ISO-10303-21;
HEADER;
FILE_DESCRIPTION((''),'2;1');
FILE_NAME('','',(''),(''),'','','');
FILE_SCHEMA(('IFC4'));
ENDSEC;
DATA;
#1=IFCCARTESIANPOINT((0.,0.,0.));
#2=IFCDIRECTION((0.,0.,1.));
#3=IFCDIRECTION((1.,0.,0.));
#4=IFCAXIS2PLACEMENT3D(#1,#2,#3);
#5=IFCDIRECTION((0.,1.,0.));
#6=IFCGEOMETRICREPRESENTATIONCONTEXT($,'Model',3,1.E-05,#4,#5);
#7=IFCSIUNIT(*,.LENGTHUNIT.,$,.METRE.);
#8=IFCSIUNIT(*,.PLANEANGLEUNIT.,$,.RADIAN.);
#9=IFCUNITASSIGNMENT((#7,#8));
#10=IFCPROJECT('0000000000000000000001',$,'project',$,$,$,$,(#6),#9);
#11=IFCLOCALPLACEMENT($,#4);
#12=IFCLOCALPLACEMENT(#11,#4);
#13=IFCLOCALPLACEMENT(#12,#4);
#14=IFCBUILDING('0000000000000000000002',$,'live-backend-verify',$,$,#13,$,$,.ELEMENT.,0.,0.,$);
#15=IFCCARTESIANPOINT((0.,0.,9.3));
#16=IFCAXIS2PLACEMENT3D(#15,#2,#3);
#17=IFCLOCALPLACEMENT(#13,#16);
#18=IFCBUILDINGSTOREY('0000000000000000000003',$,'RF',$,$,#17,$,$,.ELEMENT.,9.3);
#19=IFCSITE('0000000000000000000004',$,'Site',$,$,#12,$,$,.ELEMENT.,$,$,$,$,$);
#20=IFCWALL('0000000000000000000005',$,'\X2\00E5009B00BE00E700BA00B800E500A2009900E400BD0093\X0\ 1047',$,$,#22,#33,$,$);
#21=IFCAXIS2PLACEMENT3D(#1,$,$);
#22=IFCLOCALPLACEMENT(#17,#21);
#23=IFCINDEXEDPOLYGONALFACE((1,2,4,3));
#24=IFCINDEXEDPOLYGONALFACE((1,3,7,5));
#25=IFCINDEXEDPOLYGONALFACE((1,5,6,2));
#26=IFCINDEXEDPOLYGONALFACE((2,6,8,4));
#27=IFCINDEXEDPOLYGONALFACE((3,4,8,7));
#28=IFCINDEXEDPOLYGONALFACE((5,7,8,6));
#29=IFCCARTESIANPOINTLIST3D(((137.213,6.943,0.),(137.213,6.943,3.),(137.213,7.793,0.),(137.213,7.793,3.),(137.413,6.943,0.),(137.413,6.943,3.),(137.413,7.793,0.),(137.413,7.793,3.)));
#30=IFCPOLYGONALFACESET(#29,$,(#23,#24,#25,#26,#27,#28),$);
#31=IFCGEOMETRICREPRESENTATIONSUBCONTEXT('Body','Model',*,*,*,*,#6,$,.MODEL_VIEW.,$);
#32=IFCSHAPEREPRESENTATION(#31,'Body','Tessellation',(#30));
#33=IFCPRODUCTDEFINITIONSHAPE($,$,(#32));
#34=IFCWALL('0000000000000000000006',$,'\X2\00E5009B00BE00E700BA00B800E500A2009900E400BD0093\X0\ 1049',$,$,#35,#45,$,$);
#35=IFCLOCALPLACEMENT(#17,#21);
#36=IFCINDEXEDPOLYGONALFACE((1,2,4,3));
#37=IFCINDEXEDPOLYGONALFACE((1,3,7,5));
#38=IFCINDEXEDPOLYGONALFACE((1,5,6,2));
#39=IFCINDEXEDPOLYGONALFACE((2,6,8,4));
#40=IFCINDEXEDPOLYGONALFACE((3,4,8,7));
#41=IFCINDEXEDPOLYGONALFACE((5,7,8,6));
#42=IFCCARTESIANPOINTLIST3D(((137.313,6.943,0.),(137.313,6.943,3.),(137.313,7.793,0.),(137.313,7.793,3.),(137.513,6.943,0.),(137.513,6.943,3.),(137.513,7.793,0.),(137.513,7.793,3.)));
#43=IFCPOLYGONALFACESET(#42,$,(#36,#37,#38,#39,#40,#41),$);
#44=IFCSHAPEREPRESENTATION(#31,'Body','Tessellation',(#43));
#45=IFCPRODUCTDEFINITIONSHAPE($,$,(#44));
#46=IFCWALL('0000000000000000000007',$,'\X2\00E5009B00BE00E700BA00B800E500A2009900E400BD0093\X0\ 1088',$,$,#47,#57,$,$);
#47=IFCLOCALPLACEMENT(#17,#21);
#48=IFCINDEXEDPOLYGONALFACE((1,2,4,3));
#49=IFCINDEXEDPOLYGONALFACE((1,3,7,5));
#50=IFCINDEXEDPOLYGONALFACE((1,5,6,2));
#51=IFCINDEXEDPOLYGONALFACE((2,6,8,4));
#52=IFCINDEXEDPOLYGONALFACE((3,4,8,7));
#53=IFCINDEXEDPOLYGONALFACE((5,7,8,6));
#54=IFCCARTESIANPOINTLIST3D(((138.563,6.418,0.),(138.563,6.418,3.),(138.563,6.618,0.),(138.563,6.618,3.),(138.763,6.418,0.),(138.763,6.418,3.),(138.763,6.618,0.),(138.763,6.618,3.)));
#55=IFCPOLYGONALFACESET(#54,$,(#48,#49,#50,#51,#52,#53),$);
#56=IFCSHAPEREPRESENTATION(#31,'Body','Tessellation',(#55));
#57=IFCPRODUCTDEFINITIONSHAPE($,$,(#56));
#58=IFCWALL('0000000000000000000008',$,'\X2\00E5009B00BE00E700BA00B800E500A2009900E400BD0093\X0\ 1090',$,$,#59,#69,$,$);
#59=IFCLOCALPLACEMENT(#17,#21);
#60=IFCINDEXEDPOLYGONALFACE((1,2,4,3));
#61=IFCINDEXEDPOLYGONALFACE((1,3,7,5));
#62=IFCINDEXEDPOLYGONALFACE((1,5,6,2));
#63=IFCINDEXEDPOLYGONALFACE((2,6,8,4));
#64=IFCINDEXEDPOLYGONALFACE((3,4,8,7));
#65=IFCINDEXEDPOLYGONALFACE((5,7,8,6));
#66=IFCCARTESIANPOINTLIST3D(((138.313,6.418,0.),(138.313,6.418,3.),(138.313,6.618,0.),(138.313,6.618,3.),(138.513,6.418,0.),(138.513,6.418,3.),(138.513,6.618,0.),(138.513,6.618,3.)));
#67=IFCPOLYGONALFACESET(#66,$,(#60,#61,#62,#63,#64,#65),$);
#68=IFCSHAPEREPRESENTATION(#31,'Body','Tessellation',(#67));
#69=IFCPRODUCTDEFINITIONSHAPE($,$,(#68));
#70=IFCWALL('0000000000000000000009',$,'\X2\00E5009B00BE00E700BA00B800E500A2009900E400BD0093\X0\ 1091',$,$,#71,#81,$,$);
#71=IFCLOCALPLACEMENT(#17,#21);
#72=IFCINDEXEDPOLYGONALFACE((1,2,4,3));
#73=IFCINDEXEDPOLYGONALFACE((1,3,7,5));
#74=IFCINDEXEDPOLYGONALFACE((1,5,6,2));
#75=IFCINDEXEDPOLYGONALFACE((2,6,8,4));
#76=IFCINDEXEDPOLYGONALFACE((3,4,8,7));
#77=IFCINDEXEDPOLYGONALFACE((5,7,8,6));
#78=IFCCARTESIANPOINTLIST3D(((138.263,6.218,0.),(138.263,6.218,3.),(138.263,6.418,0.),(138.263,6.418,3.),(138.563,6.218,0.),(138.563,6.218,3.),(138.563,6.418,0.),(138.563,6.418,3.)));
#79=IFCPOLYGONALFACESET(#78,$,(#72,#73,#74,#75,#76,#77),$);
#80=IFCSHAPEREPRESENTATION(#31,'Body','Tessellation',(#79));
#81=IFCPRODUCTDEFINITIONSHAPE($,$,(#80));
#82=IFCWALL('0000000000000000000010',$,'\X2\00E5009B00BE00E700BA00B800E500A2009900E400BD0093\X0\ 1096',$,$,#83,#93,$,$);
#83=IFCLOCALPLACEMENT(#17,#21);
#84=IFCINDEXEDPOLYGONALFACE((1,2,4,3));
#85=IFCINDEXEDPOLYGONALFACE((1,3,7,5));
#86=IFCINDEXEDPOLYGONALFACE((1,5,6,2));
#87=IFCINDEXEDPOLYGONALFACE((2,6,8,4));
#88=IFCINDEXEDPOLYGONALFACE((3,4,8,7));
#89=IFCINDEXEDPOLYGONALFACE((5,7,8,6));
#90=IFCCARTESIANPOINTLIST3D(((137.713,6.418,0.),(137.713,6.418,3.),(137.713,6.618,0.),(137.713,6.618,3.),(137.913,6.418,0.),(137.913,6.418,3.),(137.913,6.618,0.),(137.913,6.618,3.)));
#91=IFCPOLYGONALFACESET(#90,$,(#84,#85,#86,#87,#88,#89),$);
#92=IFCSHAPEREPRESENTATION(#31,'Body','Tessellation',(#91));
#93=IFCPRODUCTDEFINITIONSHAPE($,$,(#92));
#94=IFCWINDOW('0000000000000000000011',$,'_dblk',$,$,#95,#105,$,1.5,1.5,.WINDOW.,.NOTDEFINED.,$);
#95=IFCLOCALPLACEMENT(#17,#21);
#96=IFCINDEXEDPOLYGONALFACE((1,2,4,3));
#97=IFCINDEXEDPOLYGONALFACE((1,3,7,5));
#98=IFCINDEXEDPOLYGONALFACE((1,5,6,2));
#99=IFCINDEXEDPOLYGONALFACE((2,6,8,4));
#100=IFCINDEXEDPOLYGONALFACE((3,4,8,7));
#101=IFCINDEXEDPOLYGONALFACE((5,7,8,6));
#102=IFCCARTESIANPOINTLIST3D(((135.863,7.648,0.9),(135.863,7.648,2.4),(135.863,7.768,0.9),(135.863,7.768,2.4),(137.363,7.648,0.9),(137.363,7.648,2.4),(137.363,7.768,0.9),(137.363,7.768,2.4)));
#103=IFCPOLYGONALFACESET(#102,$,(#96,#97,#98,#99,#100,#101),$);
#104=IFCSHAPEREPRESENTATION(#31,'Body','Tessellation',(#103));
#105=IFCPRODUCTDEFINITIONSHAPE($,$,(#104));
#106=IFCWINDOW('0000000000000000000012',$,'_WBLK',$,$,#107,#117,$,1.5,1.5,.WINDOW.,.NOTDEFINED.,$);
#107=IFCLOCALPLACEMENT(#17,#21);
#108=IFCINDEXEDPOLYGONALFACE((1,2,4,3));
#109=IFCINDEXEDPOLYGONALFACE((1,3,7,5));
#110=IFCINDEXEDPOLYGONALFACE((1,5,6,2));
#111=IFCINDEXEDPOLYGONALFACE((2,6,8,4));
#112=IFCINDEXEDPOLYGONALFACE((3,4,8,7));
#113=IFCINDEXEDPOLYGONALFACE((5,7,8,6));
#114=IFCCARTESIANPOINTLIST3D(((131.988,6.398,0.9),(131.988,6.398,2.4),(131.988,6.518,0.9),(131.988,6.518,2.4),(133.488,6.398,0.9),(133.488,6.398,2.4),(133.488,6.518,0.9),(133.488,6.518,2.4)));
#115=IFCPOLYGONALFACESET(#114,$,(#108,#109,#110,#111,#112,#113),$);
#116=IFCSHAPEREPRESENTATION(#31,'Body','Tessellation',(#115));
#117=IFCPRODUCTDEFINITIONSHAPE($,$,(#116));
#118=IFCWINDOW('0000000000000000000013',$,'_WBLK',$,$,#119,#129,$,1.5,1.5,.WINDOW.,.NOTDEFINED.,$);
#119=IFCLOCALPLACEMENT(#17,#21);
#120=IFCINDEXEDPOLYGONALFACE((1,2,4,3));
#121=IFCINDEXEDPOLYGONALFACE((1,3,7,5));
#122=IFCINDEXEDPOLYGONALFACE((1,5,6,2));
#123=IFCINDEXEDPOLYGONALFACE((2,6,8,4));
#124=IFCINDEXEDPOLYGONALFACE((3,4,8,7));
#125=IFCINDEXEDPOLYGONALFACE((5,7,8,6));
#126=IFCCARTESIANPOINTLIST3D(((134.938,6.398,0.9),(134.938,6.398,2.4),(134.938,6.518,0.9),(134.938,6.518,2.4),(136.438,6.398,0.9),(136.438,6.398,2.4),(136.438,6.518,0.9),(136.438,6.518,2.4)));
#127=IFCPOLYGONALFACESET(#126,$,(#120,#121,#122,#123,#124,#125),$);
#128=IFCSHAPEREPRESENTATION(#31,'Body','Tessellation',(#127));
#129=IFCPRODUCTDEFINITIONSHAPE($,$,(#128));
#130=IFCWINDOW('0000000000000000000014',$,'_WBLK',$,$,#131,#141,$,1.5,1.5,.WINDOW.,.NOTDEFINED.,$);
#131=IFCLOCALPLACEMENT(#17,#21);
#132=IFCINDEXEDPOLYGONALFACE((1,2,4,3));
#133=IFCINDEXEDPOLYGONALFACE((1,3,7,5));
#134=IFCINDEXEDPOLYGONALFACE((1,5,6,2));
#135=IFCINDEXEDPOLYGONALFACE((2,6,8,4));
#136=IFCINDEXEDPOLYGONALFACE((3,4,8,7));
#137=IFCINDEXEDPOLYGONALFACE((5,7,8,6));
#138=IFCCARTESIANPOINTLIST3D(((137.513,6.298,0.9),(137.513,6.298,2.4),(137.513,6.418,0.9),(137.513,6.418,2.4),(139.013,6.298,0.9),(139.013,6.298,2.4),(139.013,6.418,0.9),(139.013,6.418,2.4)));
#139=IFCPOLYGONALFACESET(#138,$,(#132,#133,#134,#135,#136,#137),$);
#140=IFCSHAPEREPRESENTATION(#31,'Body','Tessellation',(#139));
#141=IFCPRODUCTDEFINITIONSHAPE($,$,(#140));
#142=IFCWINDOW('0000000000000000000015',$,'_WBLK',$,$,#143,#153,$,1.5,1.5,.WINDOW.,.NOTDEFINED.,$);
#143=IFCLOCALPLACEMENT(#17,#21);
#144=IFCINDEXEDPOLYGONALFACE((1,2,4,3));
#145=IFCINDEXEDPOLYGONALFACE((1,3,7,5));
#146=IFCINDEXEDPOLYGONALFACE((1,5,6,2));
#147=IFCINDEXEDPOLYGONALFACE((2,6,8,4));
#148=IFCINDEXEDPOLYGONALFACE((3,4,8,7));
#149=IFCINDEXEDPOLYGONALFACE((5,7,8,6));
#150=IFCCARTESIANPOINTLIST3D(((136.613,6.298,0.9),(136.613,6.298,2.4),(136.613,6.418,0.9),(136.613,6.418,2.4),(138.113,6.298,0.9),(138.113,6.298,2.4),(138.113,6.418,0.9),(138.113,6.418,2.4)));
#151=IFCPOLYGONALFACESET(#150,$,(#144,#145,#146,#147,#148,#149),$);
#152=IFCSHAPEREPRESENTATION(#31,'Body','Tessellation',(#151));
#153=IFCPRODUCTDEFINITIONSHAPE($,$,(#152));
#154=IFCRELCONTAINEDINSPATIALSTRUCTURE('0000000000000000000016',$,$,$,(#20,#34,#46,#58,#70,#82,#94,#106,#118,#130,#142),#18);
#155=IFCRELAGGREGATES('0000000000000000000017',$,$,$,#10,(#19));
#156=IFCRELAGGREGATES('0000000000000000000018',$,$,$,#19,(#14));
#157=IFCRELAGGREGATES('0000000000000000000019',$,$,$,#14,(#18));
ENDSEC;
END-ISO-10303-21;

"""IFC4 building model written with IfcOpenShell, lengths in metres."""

from ifc_helpers import new_model, si_unit, direction, frame, frame_2d, origin_with_axes, place, context, subcontext, project, spatial, rectangle, extrude, element, save


model = new_model("IFC4")

# Units and contexts
model_context = context("Model", 3, precision=1e-05, world=origin_with_axes(), true_north=direction((0.0, 1.0, 0.0)))
body_context = subcontext(model_context, "Body", "Model", "MODEL_VIEW")
ifc_project = project(units=[si_unit("LENGTHUNIT", "METRE"), si_unit("PLANEANGLEUNIT", "RADIAN")], contexts=[model_context])

# Site, building, storey
placement = place(None, origin_with_axes())
site_placement = place(placement, origin_with_axes())
site = spatial("IfcSite", under=ifc_project, at=site_placement, Name="Site", CompositionType="ELEMENT")
building_placement = place(site_placement, origin_with_axes())
building = spatial("IfcBuilding", under=site, at=building_placement, Name="live-backend-verify", CompositionType="ELEMENT", ElevationOfRefHeight=0.0, ElevationOfTerrain=0.0)
storey_placement = place(building_placement, frame((0.0, 0.0, 9.3), z_axis=(0.0, 0.0, 1.0), x_axis=(1.0, 0.0, 0.0)))
storey = spatial("IfcBuildingStorey", under=building, at=storey_placement, Name="RF", CompositionType="ELEMENT", Elevation=9.3)

# Walls
for number, where, z_axis, x_axis, name in (
    (1, (137.313, 7.368, 0.0), (0.0, 0.0, 1.0), (0.0, -1.0, 0.0), "å\u009b¾çº¸å¢\u0099ä½\u0093 1047"),
    (2, (137.413, 7.368, 0.0), (0.0, 0.0, 1.0), (0.0, -1.0, 0.0), "å\u009b¾çº¸å¢\u0099ä½\u0093 1049"),
):
    element("IfcWall", number, at=place(storey_placement, frame(where, z_axis=z_axis, x_axis=x_axis)), inside=storey, Name=name, context=body_context, shape_type="SweptSolid", body=[
        extrude(rectangle(XDim=0.85, YDim=0.2, at=frame_2d((0.0, 0.0), x_axis=(1.0, 0.0, 0.0))), frame((0.0, 0.0, 0.0), z_axis=(0.0, 0.0, 1.0)), (0.0, 0.0, 1.0), 3.0),
    ])
for number, where, z_axis, x_axis, name in (
    (3, (138.663, 6.518, 0.0), (0.0, 0.0, 1.0), (1.0, 0.0, 0.0), "å\u009b¾çº¸å¢\u0099ä½\u0093 1088"),
    (4, (138.413, 6.518, 0.0), (0.0, 0.0, 1.0), (1.0, 0.0, 0.0), "å\u009b¾çº¸å¢\u0099ä½\u0093 1090"),
):
    element("IfcWall", number, at=place(storey_placement, frame(where, z_axis=z_axis, x_axis=x_axis)), inside=storey, Name=name, context=body_context, shape_type="SweptSolid", body=[
        extrude(rectangle(XDim=0.2, YDim=0.2, at=frame_2d((0.0, 0.0), x_axis=(1.0, 0.0, 0.0))), frame((0.0, 0.0, 0.0), z_axis=(0.0, 0.0, 1.0)), (0.0, 0.0, 1.0), 3.0),
    ])
wall_1_placement = place(storey_placement, frame((138.413, 6.318, 0.0), z_axis=(0.0, 0.0, 1.0), x_axis=(1.0, 0.0, 0.0)))
element("IfcWall", 5, at=wall_1_placement, inside=storey, Name="å\u009b¾çº¸å¢\u0099ä½\u0093 1091", context=body_context, shape_type="SweptSolid", body=[
    extrude(rectangle(XDim=0.3, YDim=0.2, at=frame_2d((0.0, 0.0), x_axis=(1.0, 0.0, 0.0))), frame((0.0, 0.0, 0.0), z_axis=(0.0, 0.0, 1.0)), (0.0, 0.0, 1.0), 3.0),
])
for number, where, z_axis, x_axis, name in (
    (6, (137.813, 6.518, 0.0), (0.0, 0.0, 1.0), (0.0, -1.0, 0.0), "å\u009b¾çº¸å¢\u0099ä½\u0093 1096"),
):
    element("IfcWall", number, at=place(storey_placement, frame(where, z_axis=z_axis, x_axis=x_axis)), inside=storey, Name=name, context=body_context, shape_type="SweptSolid", body=[
        extrude(rectangle(XDim=0.2, YDim=0.2, at=frame_2d((0.0, 0.0), x_axis=(1.0, 0.0, 0.0))), frame((0.0, 0.0, 0.0), z_axis=(0.0, 0.0, 1.0)), (0.0, 0.0, 1.0), 3.0),
    ])

# Windows
for number, where, z_axis, x_axis, name in (
    (7, (136.613, 7.708, 0.9), (0.0, 0.0, 1.0), (1.0, 0.0, 0.0), "_dblk"),
    (8, (132.738, 6.458, 0.9), (0.0, 0.0, 1.0), (1.0, 0.0, 0.0), "_WBLK"),
    (9, (135.688, 6.458, 0.9), (0.0, 0.0, 1.0), (1.0, 0.0, 0.0), "_WBLK"),
    (10, (138.263, 6.358, 0.9), (0.0, 0.0, 1.0), (1.0, 0.0, 0.0), "_WBLK"),
    (11, (137.363, 6.358, 0.9), (0.0, 0.0, 1.0), (1.0, 0.0, 0.0), "_WBLK"),
):
    element("IfcWindow", number, at=place(storey_placement, frame(where, z_axis=z_axis, x_axis=x_axis)), inside=storey, Name=name, OverallHeight=1.5, OverallWidth=1.5, PartitioningType="NOTDEFINED", PredefinedType="WINDOW", context=body_context, shape_type="SweptSolid", body=[
        extrude(rectangle(XDim=1.5, YDim=0.12, at=frame_2d((0.0, 0.0), x_axis=(1.0, 0.0, 0.0))), frame((0.0, 0.0, 0.0), z_axis=(0.0, 0.0, 1.0)), (0.0, 0.0, 1.0), 1.5),
    ])

save(model, "model.ifc")
